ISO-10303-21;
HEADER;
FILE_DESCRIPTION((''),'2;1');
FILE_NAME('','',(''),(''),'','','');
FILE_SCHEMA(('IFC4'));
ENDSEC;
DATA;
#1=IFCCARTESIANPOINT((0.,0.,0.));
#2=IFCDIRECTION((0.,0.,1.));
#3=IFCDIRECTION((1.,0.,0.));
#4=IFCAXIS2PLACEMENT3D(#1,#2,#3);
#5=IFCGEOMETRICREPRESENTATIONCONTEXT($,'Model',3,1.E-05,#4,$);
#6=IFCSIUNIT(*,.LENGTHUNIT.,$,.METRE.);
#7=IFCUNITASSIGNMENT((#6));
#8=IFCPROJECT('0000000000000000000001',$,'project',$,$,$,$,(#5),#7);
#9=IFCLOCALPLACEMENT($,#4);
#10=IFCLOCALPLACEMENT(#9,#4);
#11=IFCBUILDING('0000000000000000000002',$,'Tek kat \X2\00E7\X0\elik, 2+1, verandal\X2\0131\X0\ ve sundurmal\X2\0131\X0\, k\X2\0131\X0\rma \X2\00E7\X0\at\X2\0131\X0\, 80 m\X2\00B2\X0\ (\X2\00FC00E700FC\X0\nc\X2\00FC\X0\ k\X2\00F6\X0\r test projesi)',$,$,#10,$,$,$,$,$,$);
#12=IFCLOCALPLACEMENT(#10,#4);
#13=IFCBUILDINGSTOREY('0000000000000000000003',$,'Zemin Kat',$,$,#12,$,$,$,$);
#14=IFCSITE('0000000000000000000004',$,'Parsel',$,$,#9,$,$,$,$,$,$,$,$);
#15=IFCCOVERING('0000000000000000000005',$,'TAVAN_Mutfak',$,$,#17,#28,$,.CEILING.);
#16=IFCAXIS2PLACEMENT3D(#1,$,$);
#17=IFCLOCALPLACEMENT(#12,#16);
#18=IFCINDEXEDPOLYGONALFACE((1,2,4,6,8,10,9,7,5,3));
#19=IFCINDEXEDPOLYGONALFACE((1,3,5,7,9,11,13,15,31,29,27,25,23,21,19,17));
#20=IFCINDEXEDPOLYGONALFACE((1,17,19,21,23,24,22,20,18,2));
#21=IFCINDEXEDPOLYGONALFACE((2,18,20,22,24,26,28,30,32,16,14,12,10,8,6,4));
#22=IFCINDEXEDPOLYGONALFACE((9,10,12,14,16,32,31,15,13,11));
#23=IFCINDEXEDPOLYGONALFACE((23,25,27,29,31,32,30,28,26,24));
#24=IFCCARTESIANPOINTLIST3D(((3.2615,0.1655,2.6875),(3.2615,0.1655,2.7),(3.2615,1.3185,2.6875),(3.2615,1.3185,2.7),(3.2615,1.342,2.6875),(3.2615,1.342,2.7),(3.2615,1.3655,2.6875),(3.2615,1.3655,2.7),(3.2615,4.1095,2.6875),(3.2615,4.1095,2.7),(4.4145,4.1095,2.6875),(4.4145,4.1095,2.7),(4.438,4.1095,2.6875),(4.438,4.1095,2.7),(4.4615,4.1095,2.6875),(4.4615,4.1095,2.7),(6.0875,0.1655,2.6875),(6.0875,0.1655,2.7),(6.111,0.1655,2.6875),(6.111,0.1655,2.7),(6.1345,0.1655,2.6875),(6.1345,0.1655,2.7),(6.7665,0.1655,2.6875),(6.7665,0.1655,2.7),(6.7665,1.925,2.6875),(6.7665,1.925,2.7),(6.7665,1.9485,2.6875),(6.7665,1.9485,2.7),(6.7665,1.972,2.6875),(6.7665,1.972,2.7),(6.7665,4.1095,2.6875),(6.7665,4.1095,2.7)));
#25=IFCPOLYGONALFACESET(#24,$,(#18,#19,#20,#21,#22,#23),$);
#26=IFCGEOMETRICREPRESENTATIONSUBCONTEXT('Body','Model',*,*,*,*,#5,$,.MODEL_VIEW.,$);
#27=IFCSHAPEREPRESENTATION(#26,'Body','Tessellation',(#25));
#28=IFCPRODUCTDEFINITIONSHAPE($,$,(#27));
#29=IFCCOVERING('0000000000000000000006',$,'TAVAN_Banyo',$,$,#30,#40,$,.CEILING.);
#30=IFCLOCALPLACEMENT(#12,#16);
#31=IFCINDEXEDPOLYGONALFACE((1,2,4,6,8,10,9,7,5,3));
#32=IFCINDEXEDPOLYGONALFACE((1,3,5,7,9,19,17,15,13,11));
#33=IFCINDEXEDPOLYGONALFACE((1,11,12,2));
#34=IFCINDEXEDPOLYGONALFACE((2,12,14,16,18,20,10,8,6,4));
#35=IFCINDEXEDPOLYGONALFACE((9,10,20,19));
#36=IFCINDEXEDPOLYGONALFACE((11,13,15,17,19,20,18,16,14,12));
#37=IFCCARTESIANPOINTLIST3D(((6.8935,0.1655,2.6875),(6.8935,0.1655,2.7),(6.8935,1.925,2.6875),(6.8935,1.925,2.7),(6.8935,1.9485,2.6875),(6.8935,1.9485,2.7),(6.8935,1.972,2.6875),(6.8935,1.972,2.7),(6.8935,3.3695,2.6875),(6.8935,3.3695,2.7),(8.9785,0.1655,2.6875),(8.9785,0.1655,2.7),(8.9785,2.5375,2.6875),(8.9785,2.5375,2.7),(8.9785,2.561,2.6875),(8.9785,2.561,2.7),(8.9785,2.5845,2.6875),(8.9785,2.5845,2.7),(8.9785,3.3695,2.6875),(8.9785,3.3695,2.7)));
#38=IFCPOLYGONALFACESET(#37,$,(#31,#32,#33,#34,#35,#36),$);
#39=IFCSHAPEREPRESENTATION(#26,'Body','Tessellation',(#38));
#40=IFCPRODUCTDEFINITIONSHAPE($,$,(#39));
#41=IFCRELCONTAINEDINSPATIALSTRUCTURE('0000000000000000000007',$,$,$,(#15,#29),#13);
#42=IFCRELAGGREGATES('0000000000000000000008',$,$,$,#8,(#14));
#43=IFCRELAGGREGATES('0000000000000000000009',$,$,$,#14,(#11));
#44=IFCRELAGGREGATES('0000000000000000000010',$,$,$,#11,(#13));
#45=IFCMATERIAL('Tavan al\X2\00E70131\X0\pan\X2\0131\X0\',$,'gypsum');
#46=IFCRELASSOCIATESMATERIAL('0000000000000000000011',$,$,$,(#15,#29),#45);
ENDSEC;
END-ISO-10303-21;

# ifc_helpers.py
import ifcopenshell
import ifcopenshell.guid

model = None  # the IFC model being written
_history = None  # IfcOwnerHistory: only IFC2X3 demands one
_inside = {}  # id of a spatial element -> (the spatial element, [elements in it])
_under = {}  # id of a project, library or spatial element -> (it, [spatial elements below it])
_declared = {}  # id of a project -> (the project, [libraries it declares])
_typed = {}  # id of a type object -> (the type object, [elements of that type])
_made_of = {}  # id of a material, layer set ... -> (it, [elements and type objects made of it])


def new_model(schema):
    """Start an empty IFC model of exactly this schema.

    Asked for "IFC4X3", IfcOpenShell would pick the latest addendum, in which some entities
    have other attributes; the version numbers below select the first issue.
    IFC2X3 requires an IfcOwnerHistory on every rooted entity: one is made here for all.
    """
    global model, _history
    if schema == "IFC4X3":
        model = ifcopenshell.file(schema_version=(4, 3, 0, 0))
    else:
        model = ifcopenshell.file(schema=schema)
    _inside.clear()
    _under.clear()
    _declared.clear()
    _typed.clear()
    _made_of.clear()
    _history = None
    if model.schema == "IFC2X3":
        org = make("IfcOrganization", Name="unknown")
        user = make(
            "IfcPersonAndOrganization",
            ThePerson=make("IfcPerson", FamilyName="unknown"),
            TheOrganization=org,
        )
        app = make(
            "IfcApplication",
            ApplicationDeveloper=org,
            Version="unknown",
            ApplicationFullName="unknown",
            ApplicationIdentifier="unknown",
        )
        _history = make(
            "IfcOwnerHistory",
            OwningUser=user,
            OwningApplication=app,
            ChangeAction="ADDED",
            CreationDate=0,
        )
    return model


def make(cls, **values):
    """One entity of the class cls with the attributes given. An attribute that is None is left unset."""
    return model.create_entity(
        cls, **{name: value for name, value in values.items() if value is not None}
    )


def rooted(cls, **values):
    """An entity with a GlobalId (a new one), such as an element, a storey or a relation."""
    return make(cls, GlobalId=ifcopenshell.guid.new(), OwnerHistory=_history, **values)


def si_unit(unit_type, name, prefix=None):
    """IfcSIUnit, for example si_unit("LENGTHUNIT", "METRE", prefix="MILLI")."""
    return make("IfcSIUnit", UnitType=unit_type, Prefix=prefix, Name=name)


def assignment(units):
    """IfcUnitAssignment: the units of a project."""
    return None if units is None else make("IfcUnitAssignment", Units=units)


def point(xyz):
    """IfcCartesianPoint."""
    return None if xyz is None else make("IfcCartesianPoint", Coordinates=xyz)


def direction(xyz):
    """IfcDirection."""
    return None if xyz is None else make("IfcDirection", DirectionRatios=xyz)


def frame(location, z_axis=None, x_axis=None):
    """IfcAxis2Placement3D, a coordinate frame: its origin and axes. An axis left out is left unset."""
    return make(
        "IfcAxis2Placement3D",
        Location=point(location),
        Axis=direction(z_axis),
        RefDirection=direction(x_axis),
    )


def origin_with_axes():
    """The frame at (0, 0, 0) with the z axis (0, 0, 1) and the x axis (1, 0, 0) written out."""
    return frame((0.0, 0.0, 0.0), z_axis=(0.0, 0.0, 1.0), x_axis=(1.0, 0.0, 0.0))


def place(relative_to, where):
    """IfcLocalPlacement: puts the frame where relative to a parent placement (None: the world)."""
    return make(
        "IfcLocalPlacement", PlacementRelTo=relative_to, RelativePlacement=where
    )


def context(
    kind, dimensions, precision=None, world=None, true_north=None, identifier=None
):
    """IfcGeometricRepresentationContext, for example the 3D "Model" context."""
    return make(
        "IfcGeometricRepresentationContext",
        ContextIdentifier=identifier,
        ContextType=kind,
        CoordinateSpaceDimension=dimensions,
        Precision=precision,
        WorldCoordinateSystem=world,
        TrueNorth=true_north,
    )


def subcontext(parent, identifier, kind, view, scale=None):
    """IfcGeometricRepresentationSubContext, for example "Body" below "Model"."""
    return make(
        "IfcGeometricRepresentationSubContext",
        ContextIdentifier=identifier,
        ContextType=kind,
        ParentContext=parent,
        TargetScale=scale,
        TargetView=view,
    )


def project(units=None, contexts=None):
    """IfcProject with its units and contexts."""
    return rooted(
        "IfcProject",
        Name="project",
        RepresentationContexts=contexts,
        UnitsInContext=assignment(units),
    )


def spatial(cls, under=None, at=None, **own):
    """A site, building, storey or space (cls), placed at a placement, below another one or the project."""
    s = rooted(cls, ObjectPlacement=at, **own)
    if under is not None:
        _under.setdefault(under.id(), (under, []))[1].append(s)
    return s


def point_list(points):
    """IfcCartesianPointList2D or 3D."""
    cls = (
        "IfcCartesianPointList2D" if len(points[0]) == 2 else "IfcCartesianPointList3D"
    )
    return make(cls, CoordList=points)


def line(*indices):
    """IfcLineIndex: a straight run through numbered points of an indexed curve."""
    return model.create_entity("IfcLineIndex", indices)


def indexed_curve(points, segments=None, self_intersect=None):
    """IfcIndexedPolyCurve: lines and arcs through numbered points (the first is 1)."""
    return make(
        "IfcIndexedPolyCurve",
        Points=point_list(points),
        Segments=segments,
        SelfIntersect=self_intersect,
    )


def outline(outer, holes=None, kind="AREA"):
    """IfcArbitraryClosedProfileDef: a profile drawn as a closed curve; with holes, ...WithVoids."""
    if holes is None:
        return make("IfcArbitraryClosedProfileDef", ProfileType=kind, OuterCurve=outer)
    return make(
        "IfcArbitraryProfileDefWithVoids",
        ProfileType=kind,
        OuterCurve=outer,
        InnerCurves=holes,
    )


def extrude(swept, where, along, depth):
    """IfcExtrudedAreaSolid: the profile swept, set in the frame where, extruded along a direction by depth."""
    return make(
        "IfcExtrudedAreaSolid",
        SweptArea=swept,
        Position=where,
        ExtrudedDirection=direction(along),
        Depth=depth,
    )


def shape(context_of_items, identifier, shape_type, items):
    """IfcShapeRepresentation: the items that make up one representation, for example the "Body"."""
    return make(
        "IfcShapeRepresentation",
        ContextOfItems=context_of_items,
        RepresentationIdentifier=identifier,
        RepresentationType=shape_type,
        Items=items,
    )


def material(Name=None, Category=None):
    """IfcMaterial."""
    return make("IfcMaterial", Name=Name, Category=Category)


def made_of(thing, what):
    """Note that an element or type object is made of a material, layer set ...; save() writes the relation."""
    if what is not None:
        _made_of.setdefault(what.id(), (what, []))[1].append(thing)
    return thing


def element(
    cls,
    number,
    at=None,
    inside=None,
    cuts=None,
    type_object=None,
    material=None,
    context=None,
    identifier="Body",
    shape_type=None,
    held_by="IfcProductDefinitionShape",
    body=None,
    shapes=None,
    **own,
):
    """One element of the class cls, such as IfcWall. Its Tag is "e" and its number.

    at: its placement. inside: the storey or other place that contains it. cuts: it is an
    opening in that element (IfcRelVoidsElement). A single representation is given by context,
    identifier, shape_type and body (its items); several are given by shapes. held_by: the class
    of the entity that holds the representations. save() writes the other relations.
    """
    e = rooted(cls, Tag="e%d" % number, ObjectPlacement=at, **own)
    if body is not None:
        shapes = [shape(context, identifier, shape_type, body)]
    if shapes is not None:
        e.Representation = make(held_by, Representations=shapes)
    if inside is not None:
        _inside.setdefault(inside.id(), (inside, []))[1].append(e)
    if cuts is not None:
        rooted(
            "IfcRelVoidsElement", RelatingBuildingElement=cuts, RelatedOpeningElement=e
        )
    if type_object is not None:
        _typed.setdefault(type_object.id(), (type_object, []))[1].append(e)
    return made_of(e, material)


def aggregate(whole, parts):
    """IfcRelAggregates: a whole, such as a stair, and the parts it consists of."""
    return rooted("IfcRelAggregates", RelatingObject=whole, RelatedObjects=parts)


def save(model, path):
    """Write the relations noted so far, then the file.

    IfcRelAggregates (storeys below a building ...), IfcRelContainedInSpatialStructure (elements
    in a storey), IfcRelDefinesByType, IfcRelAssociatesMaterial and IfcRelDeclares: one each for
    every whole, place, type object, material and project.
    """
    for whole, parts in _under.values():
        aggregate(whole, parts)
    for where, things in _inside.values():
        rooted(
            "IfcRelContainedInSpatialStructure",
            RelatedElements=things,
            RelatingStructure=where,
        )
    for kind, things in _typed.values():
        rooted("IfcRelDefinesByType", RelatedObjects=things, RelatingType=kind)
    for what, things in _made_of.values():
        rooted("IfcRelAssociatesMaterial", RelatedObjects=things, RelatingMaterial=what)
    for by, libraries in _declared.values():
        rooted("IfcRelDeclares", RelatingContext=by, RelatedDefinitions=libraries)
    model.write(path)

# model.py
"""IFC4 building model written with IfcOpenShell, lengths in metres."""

from ifc_helpers import new_model, si_unit, frame, origin_with_axes, place, context, subcontext, project, spatial, line, indexed_curve, outline, extrude, material, element, save


model = new_model("IFC4")

# Units and contexts
model_context = context("Model", 3, precision=1e-05, world=origin_with_axes())
body_context = subcontext(model_context, "Body", "Model", "MODEL_VIEW")
ifc_project = project(units=[si_unit("LENGTHUNIT", "METRE")], contexts=[model_context])

# Site, building, storey
site_placement = place(None, origin_with_axes())
site = spatial("IfcSite", under=ifc_project, at=site_placement, Name="Parsel")
building_placement = place(site_placement, origin_with_axes())
building = spatial("IfcBuilding", under=site, at=building_placement, Name="Tek kat çelik, 2+1, verandalı ve sundurmalı, kırma çatı, 80 m² (üçüncü kör test projesi)")
storey_placement = place(building_placement, origin_with_axes())
storey = spatial("IfcBuildingStorey", under=building, at=storey_placement, Name="Zemin Kat")

# Coverings
ifc_material_1 = material(Name="Tavan alçıpanı", Category="gypsum")
covering_1_placement = place(storey_placement, origin_with_axes())
element("IfcCovering", 1, at=covering_1_placement, inside=storey, material=ifc_material_1, Name="TAVAN_Mutfak", PredefinedType="CEILING", context=body_context, shape_type="SweptSolid", body=[
    extrude(outline(indexed_curve([(4.4615, 4.1095), (6.7665, 4.1095), (6.7665, 1.972), (6.7665, 1.9485), (6.7665, 1.925), (6.7665, 0.1655), (6.1345, 0.1655), (6.111, 0.1655), (6.0875, 0.1655), (3.2615, 0.1655), (3.2615, 1.3185), (3.2615, 1.342), (3.2615, 1.3655), (3.2615, 4.1095), (4.4145, 4.1095), (4.438, 4.1095)], segments=[line(1, 2, 3, 4, 5, 6, 7, 8, 9, 10, 11, 12, 13, 14, 15, 16, 1)])), frame((0.0, 0.0, 2.6875), z_axis=(0.0, 0.0, 1.0), x_axis=(1.0, 0.0, 0.0)), (0.0, 0.0, 1.0), 0.0125),
])
covering_2_placement = place(storey_placement, origin_with_axes())
element("IfcCovering", 2, at=covering_2_placement, inside=storey, material=ifc_material_1, Name="TAVAN_Banyo", PredefinedType="CEILING", context=body_context, shape_type="SweptSolid", body=[
    extrude(outline(indexed_curve([(6.8935, 3.3695), (8.9785, 3.3695), (8.9785, 2.5845), (8.9785, 2.561), (8.9785, 2.5375), (8.9785, 0.1655), (6.8935, 0.1655), (6.8935, 1.925), (6.8935, 1.9485), (6.8935, 1.972)], segments=[line(1, 2, 3, 4, 5, 6, 7, 8, 9, 10, 1)])), frame((0.0, 0.0, 2.6875), z_axis=(0.0, 0.0, 1.0), x_axis=(1.0, 0.0, 0.0)), (0.0, 0.0, 1.0), 0.0125),
])

save(model, "model.ifc")
